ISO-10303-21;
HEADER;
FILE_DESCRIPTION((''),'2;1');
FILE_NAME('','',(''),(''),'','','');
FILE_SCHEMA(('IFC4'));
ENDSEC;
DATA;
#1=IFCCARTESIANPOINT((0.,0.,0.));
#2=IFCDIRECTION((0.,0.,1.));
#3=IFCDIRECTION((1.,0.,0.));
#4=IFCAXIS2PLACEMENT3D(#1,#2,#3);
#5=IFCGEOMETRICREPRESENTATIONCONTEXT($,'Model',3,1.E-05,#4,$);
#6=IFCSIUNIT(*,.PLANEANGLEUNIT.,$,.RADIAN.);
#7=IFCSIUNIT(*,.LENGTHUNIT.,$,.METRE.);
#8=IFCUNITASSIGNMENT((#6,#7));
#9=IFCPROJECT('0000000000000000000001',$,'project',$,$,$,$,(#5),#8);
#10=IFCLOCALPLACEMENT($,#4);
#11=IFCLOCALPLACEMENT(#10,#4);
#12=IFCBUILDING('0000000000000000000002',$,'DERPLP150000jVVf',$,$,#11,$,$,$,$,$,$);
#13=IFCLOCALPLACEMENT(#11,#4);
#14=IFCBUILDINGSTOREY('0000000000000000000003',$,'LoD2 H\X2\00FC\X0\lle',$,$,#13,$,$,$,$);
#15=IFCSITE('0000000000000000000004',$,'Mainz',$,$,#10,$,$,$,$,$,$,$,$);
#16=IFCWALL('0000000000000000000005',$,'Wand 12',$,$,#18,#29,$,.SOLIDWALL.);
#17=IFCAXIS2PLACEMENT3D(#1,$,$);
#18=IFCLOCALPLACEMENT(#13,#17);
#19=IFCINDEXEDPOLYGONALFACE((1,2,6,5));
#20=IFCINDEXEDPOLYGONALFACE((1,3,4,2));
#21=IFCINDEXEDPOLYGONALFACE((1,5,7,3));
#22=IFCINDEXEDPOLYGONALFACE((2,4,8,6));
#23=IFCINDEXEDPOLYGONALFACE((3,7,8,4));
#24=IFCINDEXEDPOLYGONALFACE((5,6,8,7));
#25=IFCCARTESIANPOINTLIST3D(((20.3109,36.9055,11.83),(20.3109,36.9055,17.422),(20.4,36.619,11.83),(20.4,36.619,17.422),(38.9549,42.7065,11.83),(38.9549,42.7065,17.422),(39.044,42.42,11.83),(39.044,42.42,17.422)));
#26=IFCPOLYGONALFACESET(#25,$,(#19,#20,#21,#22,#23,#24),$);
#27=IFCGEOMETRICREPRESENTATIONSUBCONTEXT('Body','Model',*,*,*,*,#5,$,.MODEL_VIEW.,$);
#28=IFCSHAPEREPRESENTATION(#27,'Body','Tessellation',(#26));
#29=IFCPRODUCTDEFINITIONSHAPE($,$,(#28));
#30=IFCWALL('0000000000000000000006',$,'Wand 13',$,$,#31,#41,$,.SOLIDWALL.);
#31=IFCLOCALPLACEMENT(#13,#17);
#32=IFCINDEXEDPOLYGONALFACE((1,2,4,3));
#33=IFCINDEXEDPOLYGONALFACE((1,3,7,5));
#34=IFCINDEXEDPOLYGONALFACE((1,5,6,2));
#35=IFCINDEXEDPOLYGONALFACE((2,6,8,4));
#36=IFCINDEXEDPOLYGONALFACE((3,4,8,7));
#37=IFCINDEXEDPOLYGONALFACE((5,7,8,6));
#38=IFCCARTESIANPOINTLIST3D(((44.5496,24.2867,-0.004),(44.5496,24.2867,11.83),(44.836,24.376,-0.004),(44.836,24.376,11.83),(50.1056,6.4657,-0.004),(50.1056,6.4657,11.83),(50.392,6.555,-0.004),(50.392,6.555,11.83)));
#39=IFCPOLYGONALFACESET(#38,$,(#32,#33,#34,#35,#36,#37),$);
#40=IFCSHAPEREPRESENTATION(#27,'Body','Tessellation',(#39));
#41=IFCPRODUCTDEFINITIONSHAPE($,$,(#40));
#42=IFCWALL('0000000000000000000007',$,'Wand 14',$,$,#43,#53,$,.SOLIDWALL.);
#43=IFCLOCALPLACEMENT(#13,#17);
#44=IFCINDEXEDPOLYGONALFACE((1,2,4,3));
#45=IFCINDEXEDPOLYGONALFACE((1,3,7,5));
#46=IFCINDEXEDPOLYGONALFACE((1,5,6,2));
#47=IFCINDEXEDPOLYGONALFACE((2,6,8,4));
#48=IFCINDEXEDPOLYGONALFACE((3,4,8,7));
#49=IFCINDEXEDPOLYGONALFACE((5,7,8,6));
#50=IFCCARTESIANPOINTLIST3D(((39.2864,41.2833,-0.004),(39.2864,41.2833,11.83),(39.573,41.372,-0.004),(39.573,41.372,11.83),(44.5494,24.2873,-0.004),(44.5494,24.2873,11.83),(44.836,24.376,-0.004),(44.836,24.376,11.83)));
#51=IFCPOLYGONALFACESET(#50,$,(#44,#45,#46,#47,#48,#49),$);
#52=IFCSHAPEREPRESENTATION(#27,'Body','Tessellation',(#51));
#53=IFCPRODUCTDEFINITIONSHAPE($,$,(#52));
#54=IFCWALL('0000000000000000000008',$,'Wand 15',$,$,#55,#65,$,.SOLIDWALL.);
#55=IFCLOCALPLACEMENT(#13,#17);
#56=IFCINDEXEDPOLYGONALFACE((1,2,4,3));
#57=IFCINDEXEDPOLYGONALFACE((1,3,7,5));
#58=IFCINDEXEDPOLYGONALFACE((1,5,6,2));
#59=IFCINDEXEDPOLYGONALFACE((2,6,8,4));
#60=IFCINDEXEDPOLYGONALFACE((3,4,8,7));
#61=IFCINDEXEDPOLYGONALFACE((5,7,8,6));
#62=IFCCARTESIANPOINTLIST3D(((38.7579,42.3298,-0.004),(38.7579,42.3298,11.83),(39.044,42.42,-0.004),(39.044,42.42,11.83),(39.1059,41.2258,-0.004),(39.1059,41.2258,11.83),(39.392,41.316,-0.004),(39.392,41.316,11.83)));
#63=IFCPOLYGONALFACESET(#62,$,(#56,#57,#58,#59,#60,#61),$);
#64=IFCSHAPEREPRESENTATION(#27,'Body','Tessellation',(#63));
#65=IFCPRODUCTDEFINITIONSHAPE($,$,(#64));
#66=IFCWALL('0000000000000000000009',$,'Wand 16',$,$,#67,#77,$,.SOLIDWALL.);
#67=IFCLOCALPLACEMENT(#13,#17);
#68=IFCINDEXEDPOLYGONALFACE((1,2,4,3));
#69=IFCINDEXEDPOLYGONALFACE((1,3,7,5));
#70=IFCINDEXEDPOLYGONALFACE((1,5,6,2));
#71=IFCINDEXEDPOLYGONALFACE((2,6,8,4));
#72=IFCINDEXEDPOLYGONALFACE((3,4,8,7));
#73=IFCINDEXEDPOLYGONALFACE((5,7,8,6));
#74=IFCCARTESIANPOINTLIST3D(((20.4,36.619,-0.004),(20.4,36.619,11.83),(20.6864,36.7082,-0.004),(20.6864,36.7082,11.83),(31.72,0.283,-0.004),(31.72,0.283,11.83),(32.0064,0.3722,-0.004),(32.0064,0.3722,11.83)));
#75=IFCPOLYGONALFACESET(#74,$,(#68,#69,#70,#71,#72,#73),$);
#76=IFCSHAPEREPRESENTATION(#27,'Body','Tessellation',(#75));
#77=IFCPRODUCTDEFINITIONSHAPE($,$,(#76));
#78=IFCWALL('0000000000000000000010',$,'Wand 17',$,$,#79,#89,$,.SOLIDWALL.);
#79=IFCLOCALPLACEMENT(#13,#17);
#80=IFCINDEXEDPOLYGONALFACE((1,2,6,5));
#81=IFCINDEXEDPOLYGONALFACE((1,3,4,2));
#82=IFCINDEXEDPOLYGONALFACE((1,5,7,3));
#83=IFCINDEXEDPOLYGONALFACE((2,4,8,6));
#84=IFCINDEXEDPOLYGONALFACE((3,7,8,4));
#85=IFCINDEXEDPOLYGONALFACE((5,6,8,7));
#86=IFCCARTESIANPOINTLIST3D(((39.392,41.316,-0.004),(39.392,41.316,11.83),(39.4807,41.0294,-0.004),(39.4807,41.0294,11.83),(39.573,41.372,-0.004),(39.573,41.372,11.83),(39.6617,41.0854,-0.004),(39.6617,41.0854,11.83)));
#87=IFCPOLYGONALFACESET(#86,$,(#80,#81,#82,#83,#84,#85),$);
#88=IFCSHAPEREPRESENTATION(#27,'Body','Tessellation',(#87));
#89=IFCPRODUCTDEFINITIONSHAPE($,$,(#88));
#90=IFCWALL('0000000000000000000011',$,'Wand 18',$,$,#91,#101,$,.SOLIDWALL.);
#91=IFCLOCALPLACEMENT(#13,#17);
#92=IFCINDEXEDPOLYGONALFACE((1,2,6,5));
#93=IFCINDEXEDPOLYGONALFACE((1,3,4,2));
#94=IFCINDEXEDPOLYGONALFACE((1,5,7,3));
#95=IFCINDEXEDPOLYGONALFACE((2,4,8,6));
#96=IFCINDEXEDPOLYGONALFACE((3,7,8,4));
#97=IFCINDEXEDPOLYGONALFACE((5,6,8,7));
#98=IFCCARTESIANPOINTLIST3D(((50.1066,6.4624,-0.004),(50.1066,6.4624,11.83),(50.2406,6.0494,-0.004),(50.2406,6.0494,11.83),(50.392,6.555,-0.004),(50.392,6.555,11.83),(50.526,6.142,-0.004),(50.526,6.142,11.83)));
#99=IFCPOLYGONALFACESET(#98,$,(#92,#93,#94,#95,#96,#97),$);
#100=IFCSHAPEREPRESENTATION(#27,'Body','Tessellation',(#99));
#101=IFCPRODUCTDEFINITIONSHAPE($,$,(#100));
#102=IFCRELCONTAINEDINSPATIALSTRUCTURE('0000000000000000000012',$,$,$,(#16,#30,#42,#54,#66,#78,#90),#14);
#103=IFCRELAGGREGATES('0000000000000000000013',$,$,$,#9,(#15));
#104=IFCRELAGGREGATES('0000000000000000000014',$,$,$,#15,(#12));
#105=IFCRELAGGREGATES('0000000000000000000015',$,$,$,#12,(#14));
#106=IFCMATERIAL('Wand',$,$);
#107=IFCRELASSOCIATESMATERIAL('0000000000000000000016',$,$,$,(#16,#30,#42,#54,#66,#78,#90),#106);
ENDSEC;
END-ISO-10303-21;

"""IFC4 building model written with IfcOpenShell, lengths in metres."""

from ifc_helpers import new_model, si_unit, frame, origin_with_axes, place, context, subcontext, project, spatial, polyline, outline, extrude, material, element, save


model = new_model("IFC4")

# Units and contexts
model_context = context("Model", 3, precision=1e-05, world=origin_with_axes())
body_context = subcontext(model_context, "Body", "Model", "MODEL_VIEW")
ifc_project = project(units=[si_unit("PLANEANGLEUNIT", "RADIAN"), si_unit("LENGTHUNIT", "METRE")], contexts=[model_context])

# Site, building, storey
site_placement = place(None, origin_with_axes())
site = spatial("IfcSite", under=ifc_project, at=site_placement, Name="Mainz")
building_placement = place(site_placement, origin_with_axes())
building = spatial("IfcBuilding", under=site, at=building_placement, Name="DERPLP150000jVVf")
storey_placement = place(building_placement, origin_with_axes())
storey = spatial("IfcBuildingStorey", under=building, at=storey_placement, Name="LoD2 Hülle")

# Walls
ifc_material_1 = material(Name="Wand")
wall_1_placement = place(storey_placement, origin_with_axes())
element("IfcWall", 1, at=wall_1_placement, inside=storey, material=ifc_material_1, Name="Wand 12", PredefinedType="SOLIDWALL", context=body_context, shape_type="SweptSolid", body=[
    extrude(outline(polyline([(0.0, 0.0), (19.5256, 0.0), (19.5256, 5.592), (0.0, 5.592), (0.0, 0.0)])), frame((20.4, 36.619, 11.83), z_axis=(0.297097, -0.954847, 0.0), x_axis=(0.954847, 0.297097, 0.0)), (0.0, 0.0, -1.0), 0.3),
])
wall_2_placement = place(storey_placement, origin_with_axes())
element("IfcWall", 2, at=wall_2_placement, inside=storey, material=ifc_material_1, Name="Wand 13", PredefinedType="SOLIDWALL", context=body_context, shape_type="SweptSolid", body=[
    extrude(outline(polyline([(0.0, 0.0), (18.667, 0.0), (18.667, 11.834), (0.0, 11.834), (0.0, 0.0)])), frame((44.836, 24.376, 11.83), z_axis=(0.954679, 0.297637, 0.0), x_axis=(0.297637, -0.954679, 0.0)), (0.0, 0.0, -1.0), 0.3),
])
wall_3_placement = place(storey_placement, origin_with_axes())
element("IfcWall", 3, at=wall_3_placement, inside=storey, material=ifc_material_1, Name="Wand 14", PredefinedType="SOLIDWALL", context=body_context, shape_type="SweptSolid", body=[
    extrude(outline(polyline([(0.0, 0.0), (17.7922, 0.0), (17.7922, 11.834), (0.0, 11.834), (0.0, 0.0)])), frame((39.573, 41.372, 11.83), z_axis=(0.955249, 0.295803, 0.0), x_axis=(0.295803, -0.955249, 0.0)), (0.0, 0.0, -1.0), 0.3),
])
wall_4_placement = place(storey_placement, origin_with_axes())
element("IfcWall", 4, at=wall_4_placement, inside=storey, material=ifc_material_1, Name="Wand 15", PredefinedType="SOLIDWALL", context=body_context, shape_type="SweptSolid", body=[
    extrude(outline(polyline([(0.0, 0.0), (1.1575, 0.0), (1.1575, 11.834), (0.0, 11.834), (0.0, 0.0)])), frame((39.044, 42.42, 11.83), z_axis=(0.953739, 0.300635, 0.0), x_axis=(0.300635, -0.953739, 0.0)), (0.0, 0.0, -1.0), 0.3),
])
wall_5_placement = place(storey_placement, origin_with_axes())
element("IfcWall", 5, at=wall_5_placement, inside=storey, material=ifc_material_1, Name="Wand 16", PredefinedType="SOLIDWALL", context=body_context, shape_type="SweptSolid", body=[
    extrude(outline(polyline([(0.0, 0.0), (38.0585, 0.0), (38.0585, 11.834), (0.0, 11.834), (0.0, 0.0)])), frame((31.72, 0.283, 11.83), z_axis=(-0.954741, -0.297437, 0.0), x_axis=(-0.297437, 0.954741, 0.0)), (0.0, 0.0, -1.0), 0.3),
])
wall_6_placement = place(storey_placement, origin_with_axes())
element("IfcWall", 6, at=wall_6_placement, inside=storey, material=ifc_material_1, Name="Wand 17", PredefinedType="SOLIDWALL", context=body_context, shape_type="SweptSolid", body=[
    extrude(outline(polyline([(0.0, 0.0), (0.1895, 0.0), (0.1895, 11.834), (0.0, 11.834), (0.0, 0.0)])), frame((39.392, 41.316, 11.83), z_axis=(-0.295569, 0.955321, 0.0), x_axis=(0.955321, 0.295569, 0.0)), (0.0, 0.0, -1.0), 0.3),
])
wall_7_placement = place(storey_placement, origin_with_axes())
element("IfcWall", 7, at=wall_7_placement, inside=storey, material=ifc_material_1, Name="Wand 18", PredefinedType="SOLIDWALL", context=body_context, shape_type="SweptSolid", body=[
    extrude(outline(polyline([(0.0, 0.0), (0.4342, 0.0), (0.4342, 11.834), (0.0, 11.834), (0.0, 0.0)])), frame((50.392, 6.555, 11.83), z_axis=(0.951186, 0.308617, 0.0), x_axis=(0.308617, -0.951186, 0.0)), (0.0, 0.0, -1.0), 0.3),
])

save(model, "model.ifc")
